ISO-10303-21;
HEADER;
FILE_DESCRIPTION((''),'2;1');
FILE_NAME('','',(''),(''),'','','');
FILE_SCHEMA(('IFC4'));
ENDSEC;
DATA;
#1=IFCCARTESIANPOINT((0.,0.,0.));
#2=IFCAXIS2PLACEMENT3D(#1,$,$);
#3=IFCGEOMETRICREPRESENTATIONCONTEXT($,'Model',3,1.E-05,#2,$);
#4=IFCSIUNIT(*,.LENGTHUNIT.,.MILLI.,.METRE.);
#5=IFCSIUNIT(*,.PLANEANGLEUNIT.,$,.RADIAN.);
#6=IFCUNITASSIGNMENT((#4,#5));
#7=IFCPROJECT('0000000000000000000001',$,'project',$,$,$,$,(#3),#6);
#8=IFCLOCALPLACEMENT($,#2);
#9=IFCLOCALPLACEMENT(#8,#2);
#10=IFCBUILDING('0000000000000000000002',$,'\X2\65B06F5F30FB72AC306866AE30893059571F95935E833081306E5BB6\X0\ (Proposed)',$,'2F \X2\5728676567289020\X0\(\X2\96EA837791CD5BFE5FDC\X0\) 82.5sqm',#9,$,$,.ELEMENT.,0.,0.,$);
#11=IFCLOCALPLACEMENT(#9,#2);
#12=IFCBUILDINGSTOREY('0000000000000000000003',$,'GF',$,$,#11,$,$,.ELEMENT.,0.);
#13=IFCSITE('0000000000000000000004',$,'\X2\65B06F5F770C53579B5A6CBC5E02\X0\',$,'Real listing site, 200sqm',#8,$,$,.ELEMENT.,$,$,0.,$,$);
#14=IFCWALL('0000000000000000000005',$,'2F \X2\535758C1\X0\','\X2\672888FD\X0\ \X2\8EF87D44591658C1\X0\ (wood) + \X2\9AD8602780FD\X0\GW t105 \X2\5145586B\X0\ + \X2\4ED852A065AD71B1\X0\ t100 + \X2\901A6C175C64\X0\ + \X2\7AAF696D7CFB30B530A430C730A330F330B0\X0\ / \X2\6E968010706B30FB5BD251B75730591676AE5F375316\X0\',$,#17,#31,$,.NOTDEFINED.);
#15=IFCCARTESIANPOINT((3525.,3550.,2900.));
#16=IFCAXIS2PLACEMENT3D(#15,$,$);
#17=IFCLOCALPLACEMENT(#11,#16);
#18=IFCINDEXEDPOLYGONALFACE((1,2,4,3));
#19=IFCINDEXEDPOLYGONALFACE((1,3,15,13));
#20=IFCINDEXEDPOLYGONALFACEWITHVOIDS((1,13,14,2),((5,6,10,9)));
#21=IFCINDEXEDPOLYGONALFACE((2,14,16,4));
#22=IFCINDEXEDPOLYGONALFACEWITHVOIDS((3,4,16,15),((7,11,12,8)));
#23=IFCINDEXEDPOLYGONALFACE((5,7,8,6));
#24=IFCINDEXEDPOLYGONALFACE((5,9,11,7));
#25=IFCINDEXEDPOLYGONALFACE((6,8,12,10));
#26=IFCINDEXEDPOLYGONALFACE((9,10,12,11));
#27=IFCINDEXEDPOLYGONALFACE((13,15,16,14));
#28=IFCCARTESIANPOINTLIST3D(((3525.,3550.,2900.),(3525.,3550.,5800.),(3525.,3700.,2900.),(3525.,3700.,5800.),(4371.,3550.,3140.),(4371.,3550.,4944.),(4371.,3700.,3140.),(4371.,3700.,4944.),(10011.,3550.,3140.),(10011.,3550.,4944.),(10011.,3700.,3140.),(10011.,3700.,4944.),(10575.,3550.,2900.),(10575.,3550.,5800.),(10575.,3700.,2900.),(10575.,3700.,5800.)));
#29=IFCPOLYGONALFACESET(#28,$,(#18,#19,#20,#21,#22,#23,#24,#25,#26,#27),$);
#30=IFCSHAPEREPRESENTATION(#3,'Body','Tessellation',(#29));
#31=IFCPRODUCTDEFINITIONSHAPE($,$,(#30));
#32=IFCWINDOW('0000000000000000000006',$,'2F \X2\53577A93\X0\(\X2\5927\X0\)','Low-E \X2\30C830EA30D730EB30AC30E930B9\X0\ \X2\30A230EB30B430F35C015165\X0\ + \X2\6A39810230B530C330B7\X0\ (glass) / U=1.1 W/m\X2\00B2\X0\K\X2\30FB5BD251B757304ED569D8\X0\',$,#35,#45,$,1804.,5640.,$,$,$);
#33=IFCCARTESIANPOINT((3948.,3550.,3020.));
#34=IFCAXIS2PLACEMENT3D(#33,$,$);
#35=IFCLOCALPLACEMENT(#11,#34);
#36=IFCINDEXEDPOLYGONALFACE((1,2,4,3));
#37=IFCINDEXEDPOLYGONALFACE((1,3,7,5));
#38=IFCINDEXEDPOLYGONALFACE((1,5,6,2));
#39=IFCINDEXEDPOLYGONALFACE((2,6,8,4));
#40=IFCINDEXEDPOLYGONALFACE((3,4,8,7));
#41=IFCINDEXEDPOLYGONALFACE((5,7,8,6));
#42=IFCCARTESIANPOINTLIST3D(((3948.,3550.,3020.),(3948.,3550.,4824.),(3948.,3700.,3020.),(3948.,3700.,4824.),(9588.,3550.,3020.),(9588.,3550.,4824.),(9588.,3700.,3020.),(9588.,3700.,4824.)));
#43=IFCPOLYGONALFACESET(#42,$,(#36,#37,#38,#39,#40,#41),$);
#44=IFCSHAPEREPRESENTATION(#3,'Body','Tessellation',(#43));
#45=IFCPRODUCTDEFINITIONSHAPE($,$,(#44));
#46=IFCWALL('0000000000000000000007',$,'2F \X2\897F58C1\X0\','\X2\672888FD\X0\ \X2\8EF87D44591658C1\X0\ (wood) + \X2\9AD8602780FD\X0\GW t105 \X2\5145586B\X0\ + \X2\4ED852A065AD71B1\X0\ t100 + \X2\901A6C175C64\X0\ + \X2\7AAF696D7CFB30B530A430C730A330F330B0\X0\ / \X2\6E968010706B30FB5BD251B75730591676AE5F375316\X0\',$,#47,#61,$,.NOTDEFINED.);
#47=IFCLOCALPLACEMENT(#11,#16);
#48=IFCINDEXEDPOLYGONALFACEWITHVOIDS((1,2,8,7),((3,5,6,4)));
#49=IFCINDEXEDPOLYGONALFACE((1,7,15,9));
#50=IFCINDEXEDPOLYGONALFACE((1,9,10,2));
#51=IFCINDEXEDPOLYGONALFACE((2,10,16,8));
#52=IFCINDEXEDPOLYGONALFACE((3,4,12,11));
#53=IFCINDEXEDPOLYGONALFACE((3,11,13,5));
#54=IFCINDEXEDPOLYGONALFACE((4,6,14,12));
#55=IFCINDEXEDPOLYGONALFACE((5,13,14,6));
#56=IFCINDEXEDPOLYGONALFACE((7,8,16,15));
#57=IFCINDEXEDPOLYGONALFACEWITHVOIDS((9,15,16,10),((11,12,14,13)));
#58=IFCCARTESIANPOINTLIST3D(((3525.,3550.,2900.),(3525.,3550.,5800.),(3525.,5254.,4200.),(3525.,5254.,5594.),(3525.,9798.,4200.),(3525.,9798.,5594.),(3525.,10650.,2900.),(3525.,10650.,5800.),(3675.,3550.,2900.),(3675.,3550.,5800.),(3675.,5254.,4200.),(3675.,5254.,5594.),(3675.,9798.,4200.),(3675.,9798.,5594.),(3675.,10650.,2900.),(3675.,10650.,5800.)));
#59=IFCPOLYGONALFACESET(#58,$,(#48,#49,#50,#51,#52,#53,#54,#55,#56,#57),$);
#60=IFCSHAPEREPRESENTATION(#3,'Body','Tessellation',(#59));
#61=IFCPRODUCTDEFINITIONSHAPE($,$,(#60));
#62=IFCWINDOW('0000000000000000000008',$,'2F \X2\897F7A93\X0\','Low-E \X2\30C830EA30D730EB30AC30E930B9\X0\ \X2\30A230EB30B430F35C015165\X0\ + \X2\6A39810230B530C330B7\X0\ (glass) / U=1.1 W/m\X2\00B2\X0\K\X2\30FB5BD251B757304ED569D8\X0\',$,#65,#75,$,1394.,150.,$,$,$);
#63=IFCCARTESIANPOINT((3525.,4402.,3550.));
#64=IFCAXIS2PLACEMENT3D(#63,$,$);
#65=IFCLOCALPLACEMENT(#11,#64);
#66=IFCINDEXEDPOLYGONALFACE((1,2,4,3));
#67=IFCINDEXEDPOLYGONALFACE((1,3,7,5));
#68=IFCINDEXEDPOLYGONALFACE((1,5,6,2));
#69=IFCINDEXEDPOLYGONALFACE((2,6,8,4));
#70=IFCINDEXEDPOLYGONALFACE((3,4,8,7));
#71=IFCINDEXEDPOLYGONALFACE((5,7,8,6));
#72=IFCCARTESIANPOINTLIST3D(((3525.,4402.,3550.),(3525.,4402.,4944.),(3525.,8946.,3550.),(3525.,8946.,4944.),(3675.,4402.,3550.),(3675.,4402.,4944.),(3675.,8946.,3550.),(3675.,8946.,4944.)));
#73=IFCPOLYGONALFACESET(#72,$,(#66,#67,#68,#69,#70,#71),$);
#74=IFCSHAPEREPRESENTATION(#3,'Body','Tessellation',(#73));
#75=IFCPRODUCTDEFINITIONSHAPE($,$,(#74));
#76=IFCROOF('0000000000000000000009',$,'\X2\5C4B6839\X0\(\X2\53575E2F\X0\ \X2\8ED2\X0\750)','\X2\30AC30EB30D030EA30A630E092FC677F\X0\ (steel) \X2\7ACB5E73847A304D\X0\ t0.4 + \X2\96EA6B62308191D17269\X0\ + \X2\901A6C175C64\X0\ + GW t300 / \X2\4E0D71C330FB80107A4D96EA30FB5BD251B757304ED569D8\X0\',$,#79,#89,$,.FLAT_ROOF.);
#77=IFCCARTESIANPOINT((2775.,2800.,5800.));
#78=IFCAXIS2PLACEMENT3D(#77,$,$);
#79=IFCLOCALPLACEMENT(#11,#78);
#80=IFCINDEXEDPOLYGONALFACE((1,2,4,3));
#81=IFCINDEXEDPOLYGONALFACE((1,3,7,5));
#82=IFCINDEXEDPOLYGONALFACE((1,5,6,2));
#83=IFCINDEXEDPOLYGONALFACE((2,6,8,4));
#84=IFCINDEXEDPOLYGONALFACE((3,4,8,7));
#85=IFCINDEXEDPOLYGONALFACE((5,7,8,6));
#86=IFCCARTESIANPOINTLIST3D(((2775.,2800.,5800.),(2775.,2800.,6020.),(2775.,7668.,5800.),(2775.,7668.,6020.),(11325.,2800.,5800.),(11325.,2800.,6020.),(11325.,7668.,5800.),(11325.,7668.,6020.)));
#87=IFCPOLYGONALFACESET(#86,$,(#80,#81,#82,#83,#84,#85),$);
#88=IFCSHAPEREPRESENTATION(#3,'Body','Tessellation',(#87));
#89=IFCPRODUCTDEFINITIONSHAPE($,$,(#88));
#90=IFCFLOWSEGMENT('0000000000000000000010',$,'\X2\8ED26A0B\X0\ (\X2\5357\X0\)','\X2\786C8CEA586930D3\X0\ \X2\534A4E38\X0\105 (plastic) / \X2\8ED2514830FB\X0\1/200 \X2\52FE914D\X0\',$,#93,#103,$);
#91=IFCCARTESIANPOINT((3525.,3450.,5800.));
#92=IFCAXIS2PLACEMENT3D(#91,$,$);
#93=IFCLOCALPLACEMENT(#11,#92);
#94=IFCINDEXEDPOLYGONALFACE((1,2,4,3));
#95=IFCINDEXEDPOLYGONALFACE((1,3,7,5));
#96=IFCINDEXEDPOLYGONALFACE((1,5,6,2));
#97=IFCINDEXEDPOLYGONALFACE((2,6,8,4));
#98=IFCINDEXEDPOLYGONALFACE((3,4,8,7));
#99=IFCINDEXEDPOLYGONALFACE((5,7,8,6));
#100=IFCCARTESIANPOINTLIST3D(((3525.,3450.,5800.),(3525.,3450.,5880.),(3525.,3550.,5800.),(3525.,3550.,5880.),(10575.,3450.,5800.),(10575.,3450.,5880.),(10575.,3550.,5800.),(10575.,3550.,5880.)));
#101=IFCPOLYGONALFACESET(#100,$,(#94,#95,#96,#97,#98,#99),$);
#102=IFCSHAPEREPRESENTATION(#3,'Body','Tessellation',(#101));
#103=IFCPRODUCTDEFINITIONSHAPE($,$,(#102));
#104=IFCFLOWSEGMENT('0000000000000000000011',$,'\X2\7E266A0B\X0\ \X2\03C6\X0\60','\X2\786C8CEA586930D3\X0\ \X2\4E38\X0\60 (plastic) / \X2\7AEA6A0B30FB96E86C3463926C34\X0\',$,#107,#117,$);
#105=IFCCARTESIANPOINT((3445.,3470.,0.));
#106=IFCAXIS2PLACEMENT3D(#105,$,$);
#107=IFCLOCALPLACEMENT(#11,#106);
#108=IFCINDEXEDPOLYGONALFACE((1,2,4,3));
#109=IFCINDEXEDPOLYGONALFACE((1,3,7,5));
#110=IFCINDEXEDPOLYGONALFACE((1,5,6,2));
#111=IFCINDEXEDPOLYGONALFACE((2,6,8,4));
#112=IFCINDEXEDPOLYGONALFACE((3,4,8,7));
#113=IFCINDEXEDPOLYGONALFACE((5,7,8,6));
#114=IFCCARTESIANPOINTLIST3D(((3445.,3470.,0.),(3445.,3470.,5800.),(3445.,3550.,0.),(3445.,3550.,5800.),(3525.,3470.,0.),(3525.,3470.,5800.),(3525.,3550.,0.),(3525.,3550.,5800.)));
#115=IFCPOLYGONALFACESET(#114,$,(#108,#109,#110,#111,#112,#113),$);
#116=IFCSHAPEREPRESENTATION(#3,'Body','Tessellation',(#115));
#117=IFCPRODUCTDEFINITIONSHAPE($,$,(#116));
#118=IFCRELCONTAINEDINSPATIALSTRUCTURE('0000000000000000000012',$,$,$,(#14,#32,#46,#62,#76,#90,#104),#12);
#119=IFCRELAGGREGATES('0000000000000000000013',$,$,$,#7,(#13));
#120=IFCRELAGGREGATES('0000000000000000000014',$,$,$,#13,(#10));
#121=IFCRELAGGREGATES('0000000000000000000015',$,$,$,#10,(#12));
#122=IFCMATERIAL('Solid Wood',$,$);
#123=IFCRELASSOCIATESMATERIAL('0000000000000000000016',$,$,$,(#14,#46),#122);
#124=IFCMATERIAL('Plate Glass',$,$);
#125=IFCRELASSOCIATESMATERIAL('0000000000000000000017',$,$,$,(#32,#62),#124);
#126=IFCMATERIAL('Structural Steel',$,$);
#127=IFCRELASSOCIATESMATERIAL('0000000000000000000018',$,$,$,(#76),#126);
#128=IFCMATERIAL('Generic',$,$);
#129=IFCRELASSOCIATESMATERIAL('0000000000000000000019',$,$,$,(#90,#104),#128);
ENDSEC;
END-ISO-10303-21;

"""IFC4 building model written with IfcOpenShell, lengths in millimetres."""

from ifc_helpers import new_model, si_unit, frame, frame_2d, origin, place, context, project, spatial, rectangle, extrude, material, element, fill, save


model = new_model("IFC4")

# Units and contexts
model_context = context("Model", 3, precision=1e-05, world=origin())
ifc_project = project(units=[si_unit("LENGTHUNIT", "METRE", prefix="MILLI"), si_unit("PLANEANGLEUNIT", "RADIAN")], contexts=[model_context])

# Site, building, storey
site_placement = place(None, origin())
site = spatial("IfcSite", under=ifc_project, at=site_placement, Name="新潟県南魚沼市", ObjectType="Real listing site, 200sqm", CompositionType="ELEMENT", RefElevation=0.0)
building_placement = place(site_placement, origin())
building = spatial("IfcBuilding", under=site, at=building_placement, Name="新潟・犬と暮らす土間広めの家 (Proposed)", ObjectType="2F 在来木造(雪荷重対応) 82.5sqm", CompositionType="ELEMENT", ElevationOfRefHeight=0.0, ElevationOfTerrain=0.0)
storey_placement = place(building_placement, origin())
storey = spatial("IfcBuildingStorey", under=building, at=storey_placement, Name="GF", CompositionType="ELEMENT", Elevation=0.0)

# Shared definitions
ifc_material_1 = material(Name="Solid Wood")

# Shared definitions
ifc_material_2 = material(Name="Plate Glass")

# Walls, openings, windows
wall_1_placement = place(storey_placement, frame((3525.0, 3550.0, 2900.0)))
wall_1 = element("IfcWall", 1, at=wall_1_placement, inside=storey, material=ifc_material_1, Name="2F 南壁", Description="木製 軸組外壁 (wood) + 高性能GW t105 充填 + 付加断熱 t100 + 通気層 + 窯業系サイディング / 準耐火・寒冷地外皮強化", PredefinedType="NOTDEFINED", context=model_context, shape_type="SweptSolid", body=[
    extrude(rectangle(XDim=7050.0, YDim=150.0, at=frame_2d((3525.0, 75.0))), frame((3525.0, 3550.0, 2900.0)), (0.0, 0.0, 1.0), 2900.0),
])
opening_1_placement = place(storey_placement, frame((3948.0, 3550.0, 3020.0)))
opening_1 = element("IfcOpeningElement", 2, at=opening_1_placement, cuts=wall_1, PredefinedType="NOTDEFINED", context=model_context, shape_type="SweptSolid", body=[
    extrude(rectangle(XDim=5640.0, YDim=150.0, at=frame_2d((2820.0, 75.0))), frame((3948.0, 3550.0, 3020.0)), (0.0, 0.0, 1.0), 1804.0),
])
window_1_placement = place(storey_placement, frame((3948.0, 3550.0, 3020.0)))
window_1 = element("IfcWindow", 3, at=window_1_placement, inside=storey, material=ifc_material_2, Name="2F 南窓(大)", Description="Low-E トリプルガラス アルゴン封入 + 樹脂サッシ (glass) / U=1.1 W/m²K・寒冷地仕様", OverallHeight=1804.0, OverallWidth=5640.0, context=model_context, shape_type="SweptSolid", body=[
    extrude(rectangle(XDim=5640.0, YDim=150.0, at=frame_2d((2820.0, 75.0))), frame((3948.0, 3550.0, 3020.0)), (0.0, 0.0, 1.0), 1804.0),
])
fill(opening_1, window_1)
wall_2_placement = place(storey_placement, frame((3525.0, 3550.0, 2900.0)))
wall_2 = element("IfcWall", 4, at=wall_2_placement, inside=storey, material=ifc_material_1, Name="2F 西壁", Description="木製 軸組外壁 (wood) + 高性能GW t105 充填 + 付加断熱 t100 + 通気層 + 窯業系サイディング / 準耐火・寒冷地外皮強化", PredefinedType="NOTDEFINED", context=model_context, shape_type="SweptSolid", body=[
    extrude(rectangle(XDim=150.0, YDim=7100.0, at=frame_2d((75.0, 3550.0))), frame((3525.0, 3550.0, 2900.0)), (0.0, 0.0, 1.0), 2900.0),
])
opening_2_placement = place(storey_placement, frame((3525.0, 4402.0, 3550.0)))
opening_2 = element("IfcOpeningElement", 5, at=opening_2_placement, cuts=wall_2, PredefinedType="NOTDEFINED", context=model_context, shape_type="SweptSolid", body=[
    extrude(rectangle(XDim=150.0, YDim=4544.0, at=frame_2d((75.0, 2272.0))), frame((3525.0, 4402.0, 3550.0)), (0.0, 0.0, 1.0), 1394.0),
])
window_2_placement = place(storey_placement, frame((3525.0, 4402.0, 3550.0)))
window_2 = element("IfcWindow", 6, at=window_2_placement, inside=storey, material=ifc_material_2, Name="2F 西窓", Description="Low-E トリプルガラス アルゴン封入 + 樹脂サッシ (glass) / U=1.1 W/m²K・寒冷地仕様", OverallHeight=1394.0, OverallWidth=150.0, context=model_context, shape_type="SweptSolid", body=[
    extrude(rectangle(XDim=150.0, YDim=4544.0, at=frame_2d((75.0, 2272.0))), frame((3525.0, 4402.0, 3550.0)), (0.0, 0.0, 1.0), 1394.0),
])
fill(opening_2, window_2)

# Roof
ifc_material_3 = material(Name="Structural Steel")
for number, where, name in (
    (7, (2775.0, 2800.0, 5800.0), "屋根(南帯 軒750)"),
):
    element("IfcRoof", number, at=place(storey_placement, frame(where)), inside=storey, material=ifc_material_3, Name=name, Description="ガルバリウム鋼板 (steel) 立平葺き t0.4 + 雪止め金物 + 通気層 + GW t300 / 不燃・耐積雪・寒冷地仕様", PredefinedType="FLAT_ROOF", context=model_context, shape_type="SweptSolid", body=[
        extrude(rectangle(XDim=8550.0, YDim=4868.0, at=frame_2d((4275.0, 2434.0))), frame((2775.0, 2800.0, 5800.0)), (0.0, 0.0, 1.0), 220.0),
    ])

# Flow segments
ifc_material_4 = material(Name="Generic")
flow_segment_1_placement = place(storey_placement, frame((3525.0, 3450.0, 5800.0)))
element("IfcFlowSegment", 8, at=flow_segment_1_placement, inside=storey, material=ifc_material_4, Name="軒樋 (南)", Description="硬質塩ビ 半丸105 (plastic) / 軒先・1/200 勾配", context=model_context, shape_type="SweptSolid", body=[
    extrude(rectangle(XDim=7050.0, YDim=100.0, at=frame_2d((3525.0, 50.0))), frame((3525.0, 3450.0, 5800.0)), (0.0, 0.0, 1.0), 80.0),
])
flow_segment_2_placement = place(storey_placement, frame((3445.0, 3470.0, 0.0)))
element("IfcFlowSegment", 9, at=flow_segment_2_placement, inside=storey, material=ifc_material_4, Name="縦樋 φ60", Description="硬質塩ビ 丸60 (plastic) / 竪樋・雨水排水", context=model_context, shape_type="SweptSolid", body=[
    extrude(rectangle(XDim=80.0, YDim=80.0, at=frame_2d((40.0, 40.0))), frame((3445.0, 3470.0, 0.0)), (0.0, 0.0, 1.0), 5800.0),
])

save(model, "model.ifc")
